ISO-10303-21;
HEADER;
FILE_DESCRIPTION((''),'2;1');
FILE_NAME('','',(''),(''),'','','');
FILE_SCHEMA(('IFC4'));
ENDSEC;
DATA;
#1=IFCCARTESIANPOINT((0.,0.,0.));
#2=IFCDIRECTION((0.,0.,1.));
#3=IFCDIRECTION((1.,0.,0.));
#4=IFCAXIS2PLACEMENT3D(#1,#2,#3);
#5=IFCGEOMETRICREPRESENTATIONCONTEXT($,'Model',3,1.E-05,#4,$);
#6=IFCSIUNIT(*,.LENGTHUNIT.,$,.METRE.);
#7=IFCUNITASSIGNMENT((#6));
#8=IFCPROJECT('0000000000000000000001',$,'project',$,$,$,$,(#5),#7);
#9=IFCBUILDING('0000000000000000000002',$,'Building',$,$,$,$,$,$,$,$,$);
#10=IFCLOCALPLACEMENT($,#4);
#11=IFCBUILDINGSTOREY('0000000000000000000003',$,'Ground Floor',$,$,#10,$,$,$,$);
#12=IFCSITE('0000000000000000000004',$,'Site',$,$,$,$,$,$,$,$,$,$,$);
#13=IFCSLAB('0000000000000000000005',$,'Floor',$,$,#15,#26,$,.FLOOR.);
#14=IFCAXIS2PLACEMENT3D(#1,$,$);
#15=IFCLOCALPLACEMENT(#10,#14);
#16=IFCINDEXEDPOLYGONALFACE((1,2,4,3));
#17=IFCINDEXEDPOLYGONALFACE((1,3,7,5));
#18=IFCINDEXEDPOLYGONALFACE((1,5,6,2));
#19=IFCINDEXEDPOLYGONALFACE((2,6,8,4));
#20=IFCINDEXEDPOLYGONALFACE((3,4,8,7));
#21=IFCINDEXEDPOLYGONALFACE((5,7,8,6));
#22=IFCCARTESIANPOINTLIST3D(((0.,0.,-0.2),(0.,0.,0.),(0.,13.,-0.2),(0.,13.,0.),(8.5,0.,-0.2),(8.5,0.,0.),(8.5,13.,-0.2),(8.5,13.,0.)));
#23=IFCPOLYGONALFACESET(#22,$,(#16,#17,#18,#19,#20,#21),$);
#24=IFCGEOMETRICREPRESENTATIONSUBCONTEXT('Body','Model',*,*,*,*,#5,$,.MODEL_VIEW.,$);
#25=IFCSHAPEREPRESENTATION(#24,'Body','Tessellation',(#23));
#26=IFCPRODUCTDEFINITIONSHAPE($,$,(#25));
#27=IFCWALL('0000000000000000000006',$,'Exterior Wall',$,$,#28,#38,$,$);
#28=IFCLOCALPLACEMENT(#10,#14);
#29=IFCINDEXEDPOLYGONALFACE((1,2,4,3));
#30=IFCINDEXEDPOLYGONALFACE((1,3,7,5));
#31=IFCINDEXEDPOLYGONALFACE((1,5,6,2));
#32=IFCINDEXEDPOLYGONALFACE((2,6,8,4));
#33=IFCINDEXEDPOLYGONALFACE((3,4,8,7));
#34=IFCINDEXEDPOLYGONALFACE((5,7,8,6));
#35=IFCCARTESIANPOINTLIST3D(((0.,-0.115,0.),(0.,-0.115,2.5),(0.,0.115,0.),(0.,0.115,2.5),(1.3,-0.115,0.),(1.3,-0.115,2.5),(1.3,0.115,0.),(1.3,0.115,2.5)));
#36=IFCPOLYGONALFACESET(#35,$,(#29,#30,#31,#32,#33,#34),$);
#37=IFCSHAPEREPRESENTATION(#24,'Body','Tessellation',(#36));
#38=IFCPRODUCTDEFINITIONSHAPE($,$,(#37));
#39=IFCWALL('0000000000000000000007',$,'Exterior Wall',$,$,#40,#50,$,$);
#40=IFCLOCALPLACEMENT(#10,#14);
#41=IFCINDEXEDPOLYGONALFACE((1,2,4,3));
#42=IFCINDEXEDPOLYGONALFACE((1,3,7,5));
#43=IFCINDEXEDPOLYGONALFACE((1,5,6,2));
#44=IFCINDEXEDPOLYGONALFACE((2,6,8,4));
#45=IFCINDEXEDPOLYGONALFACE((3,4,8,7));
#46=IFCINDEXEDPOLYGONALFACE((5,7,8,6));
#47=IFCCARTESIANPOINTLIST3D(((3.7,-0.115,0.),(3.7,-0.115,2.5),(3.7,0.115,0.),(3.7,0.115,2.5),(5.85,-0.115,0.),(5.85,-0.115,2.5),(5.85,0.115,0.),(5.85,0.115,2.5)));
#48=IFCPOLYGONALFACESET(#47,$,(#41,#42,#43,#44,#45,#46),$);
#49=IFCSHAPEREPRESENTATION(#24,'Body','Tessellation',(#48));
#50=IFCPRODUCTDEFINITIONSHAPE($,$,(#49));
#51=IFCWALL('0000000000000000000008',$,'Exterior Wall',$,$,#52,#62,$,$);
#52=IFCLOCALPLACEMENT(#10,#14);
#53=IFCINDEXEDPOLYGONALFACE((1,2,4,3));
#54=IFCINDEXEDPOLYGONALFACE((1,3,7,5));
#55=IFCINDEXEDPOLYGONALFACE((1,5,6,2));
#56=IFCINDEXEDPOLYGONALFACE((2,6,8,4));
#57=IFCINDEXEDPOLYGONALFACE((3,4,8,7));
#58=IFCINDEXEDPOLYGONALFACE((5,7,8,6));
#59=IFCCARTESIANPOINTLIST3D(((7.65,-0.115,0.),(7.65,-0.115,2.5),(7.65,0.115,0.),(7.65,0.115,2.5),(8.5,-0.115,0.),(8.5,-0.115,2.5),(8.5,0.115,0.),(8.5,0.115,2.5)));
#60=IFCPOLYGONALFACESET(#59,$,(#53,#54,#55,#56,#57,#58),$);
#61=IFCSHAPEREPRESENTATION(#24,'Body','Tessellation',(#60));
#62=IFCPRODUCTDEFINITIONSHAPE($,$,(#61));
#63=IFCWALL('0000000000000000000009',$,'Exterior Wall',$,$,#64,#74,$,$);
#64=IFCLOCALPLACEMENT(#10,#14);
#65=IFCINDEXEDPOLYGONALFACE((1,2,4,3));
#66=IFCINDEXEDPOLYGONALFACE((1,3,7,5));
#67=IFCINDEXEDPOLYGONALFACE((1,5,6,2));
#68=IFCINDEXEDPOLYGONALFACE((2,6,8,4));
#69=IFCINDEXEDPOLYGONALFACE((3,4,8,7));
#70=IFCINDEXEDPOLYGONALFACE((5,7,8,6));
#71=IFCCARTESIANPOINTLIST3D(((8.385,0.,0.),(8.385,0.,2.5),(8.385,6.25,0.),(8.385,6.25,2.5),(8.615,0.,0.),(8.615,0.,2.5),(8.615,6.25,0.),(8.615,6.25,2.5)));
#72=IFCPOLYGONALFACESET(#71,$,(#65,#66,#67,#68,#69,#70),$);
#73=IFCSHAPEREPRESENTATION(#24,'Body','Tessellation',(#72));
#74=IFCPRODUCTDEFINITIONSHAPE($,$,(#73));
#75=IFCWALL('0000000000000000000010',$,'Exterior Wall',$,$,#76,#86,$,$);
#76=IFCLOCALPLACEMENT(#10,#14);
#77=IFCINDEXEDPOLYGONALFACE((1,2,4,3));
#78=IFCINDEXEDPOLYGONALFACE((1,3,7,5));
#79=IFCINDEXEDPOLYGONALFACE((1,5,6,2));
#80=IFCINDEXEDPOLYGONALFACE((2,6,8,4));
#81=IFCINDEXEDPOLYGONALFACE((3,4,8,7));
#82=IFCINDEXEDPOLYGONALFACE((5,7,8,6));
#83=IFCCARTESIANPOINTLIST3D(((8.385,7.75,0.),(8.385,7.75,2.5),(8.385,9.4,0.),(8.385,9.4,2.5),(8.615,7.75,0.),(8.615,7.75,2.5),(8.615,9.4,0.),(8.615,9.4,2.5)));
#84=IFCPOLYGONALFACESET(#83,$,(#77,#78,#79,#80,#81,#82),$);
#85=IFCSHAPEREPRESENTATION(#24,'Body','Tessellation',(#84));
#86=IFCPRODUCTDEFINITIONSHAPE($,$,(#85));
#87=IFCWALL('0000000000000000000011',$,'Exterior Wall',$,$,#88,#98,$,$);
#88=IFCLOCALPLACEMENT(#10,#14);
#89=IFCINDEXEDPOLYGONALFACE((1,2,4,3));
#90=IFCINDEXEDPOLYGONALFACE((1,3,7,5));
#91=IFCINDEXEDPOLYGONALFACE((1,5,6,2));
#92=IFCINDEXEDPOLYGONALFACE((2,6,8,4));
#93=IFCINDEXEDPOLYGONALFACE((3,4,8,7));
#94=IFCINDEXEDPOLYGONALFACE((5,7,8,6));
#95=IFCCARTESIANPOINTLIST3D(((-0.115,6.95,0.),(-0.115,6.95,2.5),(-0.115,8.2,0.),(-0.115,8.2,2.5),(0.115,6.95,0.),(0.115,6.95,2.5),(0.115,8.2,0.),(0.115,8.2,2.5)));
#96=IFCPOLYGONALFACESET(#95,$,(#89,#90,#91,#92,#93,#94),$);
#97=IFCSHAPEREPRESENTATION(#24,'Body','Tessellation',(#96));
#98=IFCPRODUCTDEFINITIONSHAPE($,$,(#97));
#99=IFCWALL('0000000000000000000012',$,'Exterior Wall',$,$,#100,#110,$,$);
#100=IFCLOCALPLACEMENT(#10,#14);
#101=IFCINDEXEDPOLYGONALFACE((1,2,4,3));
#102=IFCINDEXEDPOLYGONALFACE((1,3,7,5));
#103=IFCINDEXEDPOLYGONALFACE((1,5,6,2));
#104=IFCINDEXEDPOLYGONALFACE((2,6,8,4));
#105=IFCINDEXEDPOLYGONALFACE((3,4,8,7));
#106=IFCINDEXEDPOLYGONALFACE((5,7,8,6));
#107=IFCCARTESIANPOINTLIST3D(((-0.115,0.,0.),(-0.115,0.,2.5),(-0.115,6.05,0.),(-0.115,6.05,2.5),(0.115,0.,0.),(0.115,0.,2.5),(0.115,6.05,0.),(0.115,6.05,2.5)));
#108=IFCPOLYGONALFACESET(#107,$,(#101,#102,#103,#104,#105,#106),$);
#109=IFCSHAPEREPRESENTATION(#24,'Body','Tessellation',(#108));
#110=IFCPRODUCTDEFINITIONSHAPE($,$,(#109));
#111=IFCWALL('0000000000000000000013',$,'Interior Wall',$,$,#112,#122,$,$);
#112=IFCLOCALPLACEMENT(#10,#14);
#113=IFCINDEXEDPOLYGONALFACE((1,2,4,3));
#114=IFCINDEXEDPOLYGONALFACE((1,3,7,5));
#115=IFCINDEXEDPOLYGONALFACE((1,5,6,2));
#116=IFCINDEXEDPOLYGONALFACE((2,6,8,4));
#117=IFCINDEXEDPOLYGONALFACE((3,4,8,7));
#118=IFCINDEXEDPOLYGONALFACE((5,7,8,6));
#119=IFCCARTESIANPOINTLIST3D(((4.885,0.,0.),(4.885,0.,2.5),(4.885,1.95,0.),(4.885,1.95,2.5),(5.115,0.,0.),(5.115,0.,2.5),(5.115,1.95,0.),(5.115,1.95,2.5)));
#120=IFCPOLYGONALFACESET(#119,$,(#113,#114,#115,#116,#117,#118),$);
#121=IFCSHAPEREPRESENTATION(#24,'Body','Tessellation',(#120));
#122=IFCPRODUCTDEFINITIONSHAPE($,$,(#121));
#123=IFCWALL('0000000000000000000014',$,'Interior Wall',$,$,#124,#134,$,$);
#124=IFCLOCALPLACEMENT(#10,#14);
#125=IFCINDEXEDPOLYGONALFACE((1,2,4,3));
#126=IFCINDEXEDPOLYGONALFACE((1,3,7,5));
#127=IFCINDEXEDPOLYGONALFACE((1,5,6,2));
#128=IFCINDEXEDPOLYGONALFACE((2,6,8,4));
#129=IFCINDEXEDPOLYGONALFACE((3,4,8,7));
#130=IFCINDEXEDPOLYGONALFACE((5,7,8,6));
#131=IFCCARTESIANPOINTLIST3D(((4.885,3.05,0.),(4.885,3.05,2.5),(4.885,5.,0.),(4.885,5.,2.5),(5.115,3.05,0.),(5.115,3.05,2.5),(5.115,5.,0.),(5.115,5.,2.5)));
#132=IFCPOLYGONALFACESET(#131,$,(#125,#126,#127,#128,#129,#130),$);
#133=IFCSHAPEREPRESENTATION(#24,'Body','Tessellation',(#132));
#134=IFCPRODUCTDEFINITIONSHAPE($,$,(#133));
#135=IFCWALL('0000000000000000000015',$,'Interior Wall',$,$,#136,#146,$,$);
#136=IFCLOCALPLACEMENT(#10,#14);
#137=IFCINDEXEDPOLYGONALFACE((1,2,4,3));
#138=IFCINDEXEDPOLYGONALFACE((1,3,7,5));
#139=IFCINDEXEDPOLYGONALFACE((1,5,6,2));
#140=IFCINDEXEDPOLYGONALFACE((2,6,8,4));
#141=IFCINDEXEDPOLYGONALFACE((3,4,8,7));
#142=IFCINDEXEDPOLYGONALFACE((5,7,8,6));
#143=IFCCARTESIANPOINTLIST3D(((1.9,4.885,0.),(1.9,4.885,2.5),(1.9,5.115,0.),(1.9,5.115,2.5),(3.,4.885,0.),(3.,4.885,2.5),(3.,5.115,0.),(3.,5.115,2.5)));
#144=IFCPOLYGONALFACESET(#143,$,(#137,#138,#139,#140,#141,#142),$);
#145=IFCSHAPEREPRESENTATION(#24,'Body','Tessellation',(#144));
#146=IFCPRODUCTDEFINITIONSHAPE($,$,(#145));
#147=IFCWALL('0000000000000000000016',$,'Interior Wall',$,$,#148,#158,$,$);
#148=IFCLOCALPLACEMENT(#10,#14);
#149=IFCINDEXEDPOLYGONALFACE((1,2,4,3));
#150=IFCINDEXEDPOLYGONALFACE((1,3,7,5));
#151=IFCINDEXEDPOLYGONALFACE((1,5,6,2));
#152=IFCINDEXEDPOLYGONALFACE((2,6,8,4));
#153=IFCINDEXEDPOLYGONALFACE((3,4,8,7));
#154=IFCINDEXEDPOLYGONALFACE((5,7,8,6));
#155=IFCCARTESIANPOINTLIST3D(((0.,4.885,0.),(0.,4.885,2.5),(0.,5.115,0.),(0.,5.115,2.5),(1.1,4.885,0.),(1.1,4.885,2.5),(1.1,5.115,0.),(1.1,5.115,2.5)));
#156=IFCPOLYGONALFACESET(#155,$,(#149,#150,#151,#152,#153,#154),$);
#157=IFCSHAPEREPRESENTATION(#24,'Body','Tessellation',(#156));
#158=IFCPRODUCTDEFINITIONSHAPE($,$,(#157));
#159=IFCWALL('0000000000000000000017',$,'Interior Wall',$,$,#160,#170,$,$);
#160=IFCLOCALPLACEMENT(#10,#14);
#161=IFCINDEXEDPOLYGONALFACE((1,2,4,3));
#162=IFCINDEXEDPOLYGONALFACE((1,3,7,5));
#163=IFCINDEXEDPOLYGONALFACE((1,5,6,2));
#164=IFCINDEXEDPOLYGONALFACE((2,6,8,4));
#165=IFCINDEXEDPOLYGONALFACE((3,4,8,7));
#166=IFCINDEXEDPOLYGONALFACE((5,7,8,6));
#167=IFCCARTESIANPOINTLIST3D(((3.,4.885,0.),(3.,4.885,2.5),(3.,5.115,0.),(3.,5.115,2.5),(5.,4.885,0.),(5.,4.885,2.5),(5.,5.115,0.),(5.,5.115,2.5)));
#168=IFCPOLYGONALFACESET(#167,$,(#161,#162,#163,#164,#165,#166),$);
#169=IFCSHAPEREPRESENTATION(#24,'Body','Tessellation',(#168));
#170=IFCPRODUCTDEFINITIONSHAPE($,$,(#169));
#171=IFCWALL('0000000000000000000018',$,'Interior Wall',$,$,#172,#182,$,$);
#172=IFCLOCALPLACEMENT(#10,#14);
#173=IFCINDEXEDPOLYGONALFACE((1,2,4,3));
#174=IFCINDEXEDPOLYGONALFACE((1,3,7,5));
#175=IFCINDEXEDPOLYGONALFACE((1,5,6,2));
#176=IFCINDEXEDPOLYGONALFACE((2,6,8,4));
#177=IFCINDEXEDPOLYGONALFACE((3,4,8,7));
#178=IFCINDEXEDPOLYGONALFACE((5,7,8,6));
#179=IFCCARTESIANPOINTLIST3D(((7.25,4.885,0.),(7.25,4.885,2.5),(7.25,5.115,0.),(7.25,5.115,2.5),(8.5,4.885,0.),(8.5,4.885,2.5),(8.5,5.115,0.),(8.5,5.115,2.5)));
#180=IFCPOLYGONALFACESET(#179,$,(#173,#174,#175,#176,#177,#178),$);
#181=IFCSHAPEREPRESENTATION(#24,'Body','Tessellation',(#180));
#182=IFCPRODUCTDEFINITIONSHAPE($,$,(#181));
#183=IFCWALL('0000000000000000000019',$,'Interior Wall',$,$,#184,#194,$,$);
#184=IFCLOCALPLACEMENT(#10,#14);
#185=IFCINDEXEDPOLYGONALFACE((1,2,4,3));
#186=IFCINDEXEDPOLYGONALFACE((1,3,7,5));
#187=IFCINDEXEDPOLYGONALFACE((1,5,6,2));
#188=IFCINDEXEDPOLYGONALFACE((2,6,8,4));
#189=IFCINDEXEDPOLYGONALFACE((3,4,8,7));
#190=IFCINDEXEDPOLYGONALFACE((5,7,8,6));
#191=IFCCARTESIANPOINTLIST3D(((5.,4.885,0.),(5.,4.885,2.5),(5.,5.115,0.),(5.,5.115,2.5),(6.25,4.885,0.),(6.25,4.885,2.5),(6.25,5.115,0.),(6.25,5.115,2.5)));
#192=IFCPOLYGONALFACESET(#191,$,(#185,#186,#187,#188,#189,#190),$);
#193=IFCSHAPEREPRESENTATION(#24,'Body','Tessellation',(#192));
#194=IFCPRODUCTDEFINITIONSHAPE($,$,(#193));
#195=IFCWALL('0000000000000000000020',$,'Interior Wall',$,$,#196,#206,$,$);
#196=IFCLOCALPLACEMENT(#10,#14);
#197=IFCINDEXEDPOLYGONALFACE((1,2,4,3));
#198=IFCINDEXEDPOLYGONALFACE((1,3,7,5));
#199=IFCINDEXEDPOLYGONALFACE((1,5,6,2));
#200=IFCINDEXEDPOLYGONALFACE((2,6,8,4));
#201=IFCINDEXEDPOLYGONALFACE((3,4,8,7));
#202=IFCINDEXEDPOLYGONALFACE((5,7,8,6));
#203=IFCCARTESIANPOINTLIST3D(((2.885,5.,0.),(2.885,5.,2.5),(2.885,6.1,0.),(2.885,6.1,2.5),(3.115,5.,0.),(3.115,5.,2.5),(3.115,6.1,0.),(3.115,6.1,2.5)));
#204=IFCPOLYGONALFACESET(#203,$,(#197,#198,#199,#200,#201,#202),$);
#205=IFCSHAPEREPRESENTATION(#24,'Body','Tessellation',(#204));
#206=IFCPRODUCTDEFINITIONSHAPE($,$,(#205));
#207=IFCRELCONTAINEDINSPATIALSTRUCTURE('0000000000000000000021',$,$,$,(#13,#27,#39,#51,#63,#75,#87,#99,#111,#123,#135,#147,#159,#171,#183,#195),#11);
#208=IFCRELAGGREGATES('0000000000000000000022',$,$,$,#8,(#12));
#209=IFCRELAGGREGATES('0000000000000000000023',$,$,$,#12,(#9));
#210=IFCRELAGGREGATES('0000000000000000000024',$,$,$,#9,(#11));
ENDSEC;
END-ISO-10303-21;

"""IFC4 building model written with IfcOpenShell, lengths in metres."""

from ifc_helpers import new_model, si_unit, frame, origin_with_axes, place, context, subcontext, project, spatial, indexed_curve, outline, extrude, element, save


model = new_model("IFC4")

# Units and contexts
model_context = context("Model", 3, precision=1e-05, world=origin_with_axes())
body_context = subcontext(model_context, "Body", "Model", "MODEL_VIEW")
ifc_project = project(units=[si_unit("LENGTHUNIT", "METRE")], contexts=[model_context])

# Site, building, storey
site = spatial("IfcSite", under=ifc_project, Name="Site")
building = spatial("IfcBuilding", under=site, Name="Building")
storey_placement = place(None, origin_with_axes())
storey = spatial("IfcBuildingStorey", under=building, at=storey_placement, Name="Ground Floor")

# Slab
slab_placement = place(storey_placement, frame((0.0, 0.0, -0.2), z_axis=(0.0, 0.0, 1.0), x_axis=(1.0, 0.0, 0.0)))
element("IfcSlab", 1, at=slab_placement, inside=storey, Name="Floor", PredefinedType="FLOOR", context=body_context, shape_type="SweptSolid", body=[
    extrude(outline(indexed_curve([(0.0, 0.0), (8.5, 0.0), (8.5, 13.0), (0.0, 13.0)])), None, (0.0, 0.0, 1.0), 0.2),
])

# Walls
wall_1_placement = place(storey_placement, origin_with_axes())
element("IfcWall", 2, at=wall_1_placement, inside=storey, Name="Exterior Wall", context=body_context, shape_type="SweptSolid", body=[
    extrude(outline(indexed_curve([(0.0, 0.0), (0.0, 0.23), (1.3, 0.23), (1.3, 0.0), (0.0, 0.0)], self_intersect=False)), frame((0.0, -0.115, 0.0), z_axis=(0.0, 0.0, 1.0), x_axis=(1.0, 0.0, 0.0)), (0.0, 0.0, 1.0), 2.5),
])
wall_2_placement = place(storey_placement, frame((3.7, 0.0, 0.0), z_axis=(0.0, 0.0, 1.0), x_axis=(1.0, 0.0, 0.0)))
element("IfcWall", 3, at=wall_2_placement, inside=storey, Name="Exterior Wall", context=body_context, shape_type="SweptSolid", body=[
    extrude(outline(indexed_curve([(0.0, 0.0), (0.0, 0.23), (2.15, 0.23), (2.15, 0.0), (0.0, 0.0)], self_intersect=False)), frame((0.0, -0.115, 0.0), z_axis=(0.0, 0.0, 1.0), x_axis=(1.0, 0.0, 0.0)), (0.0, 0.0, 1.0), 2.5),
])
wall_3_placement = place(storey_placement, frame((7.65, 0.0, 0.0), z_axis=(0.0, 0.0, 1.0), x_axis=(1.0, 0.0, 0.0)))
element("IfcWall", 4, at=wall_3_placement, inside=storey, Name="Exterior Wall", context=body_context, shape_type="SweptSolid", body=[
    extrude(outline(indexed_curve([(0.0, 0.0), (0.0, 0.23), (0.85, 0.23), (0.85, 0.0), (0.0, 0.0)], self_intersect=False)), frame((0.0, -0.115, 0.0), z_axis=(0.0, 0.0, 1.0), x_axis=(1.0, 0.0, 0.0)), (0.0, 0.0, 1.0), 2.5),
])
wall_4_placement = place(storey_placement, frame((8.5, 0.0, 0.0), z_axis=(0.0, 0.0, 1.0), x_axis=(0.0, 1.0, 0.0)))
element("IfcWall", 5, at=wall_4_placement, inside=storey, Name="Exterior Wall", context=body_context, shape_type="SweptSolid", body=[
    extrude(outline(indexed_curve([(0.0, 0.0), (0.0, 0.23), (6.25, 0.23), (6.25, 0.0), (0.0, 0.0)], self_intersect=False)), frame((0.0, -0.115, 0.0), z_axis=(0.0, 0.0, 1.0), x_axis=(1.0, 0.0, 0.0)), (0.0, 0.0, 1.0), 2.5),
])
wall_5_placement = place(storey_placement, frame((8.5, 7.75, 0.0), z_axis=(0.0, 0.0, 1.0), x_axis=(0.0, 1.0, 0.0)))
element("IfcWall", 6, at=wall_5_placement, inside=storey, Name="Exterior Wall", context=body_context, shape_type="SweptSolid", body=[
    extrude(outline(indexed_curve([(0.0, 0.0), (0.0, 0.23), (1.65, 0.23), (1.65, 0.0), (0.0, 0.0)], self_intersect=False)), frame((0.0, -0.115, 0.0), z_axis=(0.0, 0.0, 1.0), x_axis=(1.0, 0.0, 0.0)), (0.0, 0.0, 1.0), 2.5),
])
wall_6_placement = place(storey_placement, frame((0.0, 8.2, 0.0), z_axis=(0.0, 0.0, 1.0), x_axis=(0.0, -1.0, 0.0)))
element("IfcWall", 7, at=wall_6_placement, inside=storey, Name="Exterior Wall", context=body_context, shape_type="SweptSolid", body=[
    extrude(outline(indexed_curve([(0.0, 0.0), (0.0, 0.23), (1.25, 0.23), (1.25, 0.0), (0.0, 0.0)], self_intersect=False)), frame((0.0, -0.115, 0.0), z_axis=(0.0, 0.0, 1.0), x_axis=(1.0, 0.0, 0.0)), (0.0, 0.0, 1.0), 2.5),
])
wall_7_placement = place(storey_placement, frame((0.0, 6.05, 0.0), z_axis=(0.0, 0.0, 1.0), x_axis=(0.0, -1.0, 0.0)))
element("IfcWall", 8, at=wall_7_placement, inside=storey, Name="Exterior Wall", context=body_context, shape_type="SweptSolid", body=[
    extrude(outline(indexed_curve([(0.0, 0.0), (0.0, 0.23), (6.05, 0.23), (6.05, 0.0), (0.0, 0.0)], self_intersect=False)), frame((0.0, -0.115, 0.0), z_axis=(0.0, 0.0, 1.0), x_axis=(1.0, 0.0, 0.0)), (0.0, 0.0, 1.0), 2.5),
])
wall_8_placement = place(storey_placement, frame((5.0, 0.0, 0.0), z_axis=(0.0, 0.0, 1.0), x_axis=(0.0, 1.0, 0.0)))
element("IfcWall", 9, at=wall_8_placement, inside=storey, Name="Interior Wall", context=body_context, shape_type="SweptSolid", body=[
    extrude(outline(indexed_curve([(0.0, 0.0), (0.0, 0.23), (1.95, 0.23), (1.95, 0.0), (0.0, 0.0)], self_intersect=False)), frame((0.0, -0.115, 0.0), z_axis=(0.0, 0.0, 1.0), x_axis=(1.0, 0.0, 0.0)), (0.0, 0.0, 1.0), 2.5),
])
wall_9_placement = place(storey_placement, frame((5.0, 3.05, 0.0), z_axis=(0.0, 0.0, 1.0), x_axis=(0.0, 1.0, 0.0)))
element("IfcWall", 10, at=wall_9_placement, inside=storey, Name="Interior Wall", context=body_context, shape_type="SweptSolid", body=[
    extrude(outline(indexed_curve([(0.0, 0.0), (0.0, 0.23), (1.95, 0.23), (1.95, 0.0), (0.0, 0.0)], self_intersect=False)), frame((0.0, -0.115, 0.0), z_axis=(0.0, 0.0, 1.0), x_axis=(1.0, 0.0, 0.0)), (0.0, 0.0, 1.0), 2.5),
])
for number, where, z_axis, x_axis, name in (
    (11, (3.0, 5.0, 0.0), (0.0, 0.0, 1.0), (-1.0, 0.0, 0.0), "Interior Wall"),
    (12, (1.1, 5.0, 0.0), (0.0, 0.0, 1.0), (-1.0, 0.0, 0.0), "Interior Wall"),
):
    element("IfcWall", number, at=place(storey_placement, frame(where, z_axis=z_axis, x_axis=x_axis)), inside=storey, Name=name, context=body_context, shape_type="SweptSolid", body=[
        extrude(outline(indexed_curve([(0.0, 0.0), (0.0, 0.23), (1.1, 0.23), (1.1, 0.0), (0.0, 0.0)], self_intersect=False)), frame((0.0, -0.115, 0.0), z_axis=(0.0, 0.0, 1.0), x_axis=(1.0, 0.0, 0.0)), (0.0, 0.0, 1.0), 2.5),
    ])
wall_10_placement = place(storey_placement, frame((5.0, 5.0, 0.0), z_axis=(0.0, 0.0, 1.0), x_axis=(-1.0, 0.0, 0.0)))
element("IfcWall", 13, at=wall_10_placement, inside=storey, Name="Interior Wall", context=body_context, shape_type="SweptSolid", body=[
    extrude(outline(indexed_curve([(0.0, 0.0), (0.0, 0.23), (2.0, 0.23), (2.0, 0.0), (0.0, 0.0)], self_intersect=False)), frame((0.0, -0.115, 0.0), z_axis=(0.0, 0.0, 1.0), x_axis=(1.0, 0.0, 0.0)), (0.0, 0.0, 1.0), 2.5),
])
for number, where, z_axis, x_axis, name in (
    (14, (8.5, 5.0, 0.0), (0.0, 0.0, 1.0), (-1.0, 0.0, 0.0), "Interior Wall"),
    (15, (6.25, 5.0, 0.0), (0.0, 0.0, 1.0), (-1.0, 0.0, 0.0), "Interior Wall"),
):
    element("IfcWall", number, at=place(storey_placement, frame(where, z_axis=z_axis, x_axis=x_axis)), inside=storey, Name=name, context=body_context, shape_type="SweptSolid", body=[
        extrude(outline(indexed_curve([(0.0, 0.0), (0.0, 0.23), (1.25, 0.23), (1.25, 0.0), (0.0, 0.0)], self_intersect=False)), frame((0.0, -0.115, 0.0), z_axis=(0.0, 0.0, 1.0), x_axis=(1.0, 0.0, 0.0)), (0.0, 0.0, 1.0), 2.5),
    ])
for number, where, z_axis, x_axis, name in (
    (16, (3.0, 5.0, 0.0), (0.0, 0.0, 1.0), (0.0, 1.0, 0.0), "Interior Wall"),
):
    element("IfcWall", number, at=place(storey_placement, frame(where, z_axis=z_axis, x_axis=x_axis)), inside=storey, Name=name, context=body_context, shape_type="SweptSolid", body=[
        extrude(outline(indexed_curve([(0.0, 0.0), (0.0, 0.23), (1.1, 0.23), (1.1, 0.0), (0.0, 0.0)], self_intersect=False)), frame((0.0, -0.115, 0.0), z_axis=(0.0, 0.0, 1.0), x_axis=(1.0, 0.0, 0.0)), (0.0, 0.0, 1.0), 2.5),
    ])

save(model, "model.ifc")
